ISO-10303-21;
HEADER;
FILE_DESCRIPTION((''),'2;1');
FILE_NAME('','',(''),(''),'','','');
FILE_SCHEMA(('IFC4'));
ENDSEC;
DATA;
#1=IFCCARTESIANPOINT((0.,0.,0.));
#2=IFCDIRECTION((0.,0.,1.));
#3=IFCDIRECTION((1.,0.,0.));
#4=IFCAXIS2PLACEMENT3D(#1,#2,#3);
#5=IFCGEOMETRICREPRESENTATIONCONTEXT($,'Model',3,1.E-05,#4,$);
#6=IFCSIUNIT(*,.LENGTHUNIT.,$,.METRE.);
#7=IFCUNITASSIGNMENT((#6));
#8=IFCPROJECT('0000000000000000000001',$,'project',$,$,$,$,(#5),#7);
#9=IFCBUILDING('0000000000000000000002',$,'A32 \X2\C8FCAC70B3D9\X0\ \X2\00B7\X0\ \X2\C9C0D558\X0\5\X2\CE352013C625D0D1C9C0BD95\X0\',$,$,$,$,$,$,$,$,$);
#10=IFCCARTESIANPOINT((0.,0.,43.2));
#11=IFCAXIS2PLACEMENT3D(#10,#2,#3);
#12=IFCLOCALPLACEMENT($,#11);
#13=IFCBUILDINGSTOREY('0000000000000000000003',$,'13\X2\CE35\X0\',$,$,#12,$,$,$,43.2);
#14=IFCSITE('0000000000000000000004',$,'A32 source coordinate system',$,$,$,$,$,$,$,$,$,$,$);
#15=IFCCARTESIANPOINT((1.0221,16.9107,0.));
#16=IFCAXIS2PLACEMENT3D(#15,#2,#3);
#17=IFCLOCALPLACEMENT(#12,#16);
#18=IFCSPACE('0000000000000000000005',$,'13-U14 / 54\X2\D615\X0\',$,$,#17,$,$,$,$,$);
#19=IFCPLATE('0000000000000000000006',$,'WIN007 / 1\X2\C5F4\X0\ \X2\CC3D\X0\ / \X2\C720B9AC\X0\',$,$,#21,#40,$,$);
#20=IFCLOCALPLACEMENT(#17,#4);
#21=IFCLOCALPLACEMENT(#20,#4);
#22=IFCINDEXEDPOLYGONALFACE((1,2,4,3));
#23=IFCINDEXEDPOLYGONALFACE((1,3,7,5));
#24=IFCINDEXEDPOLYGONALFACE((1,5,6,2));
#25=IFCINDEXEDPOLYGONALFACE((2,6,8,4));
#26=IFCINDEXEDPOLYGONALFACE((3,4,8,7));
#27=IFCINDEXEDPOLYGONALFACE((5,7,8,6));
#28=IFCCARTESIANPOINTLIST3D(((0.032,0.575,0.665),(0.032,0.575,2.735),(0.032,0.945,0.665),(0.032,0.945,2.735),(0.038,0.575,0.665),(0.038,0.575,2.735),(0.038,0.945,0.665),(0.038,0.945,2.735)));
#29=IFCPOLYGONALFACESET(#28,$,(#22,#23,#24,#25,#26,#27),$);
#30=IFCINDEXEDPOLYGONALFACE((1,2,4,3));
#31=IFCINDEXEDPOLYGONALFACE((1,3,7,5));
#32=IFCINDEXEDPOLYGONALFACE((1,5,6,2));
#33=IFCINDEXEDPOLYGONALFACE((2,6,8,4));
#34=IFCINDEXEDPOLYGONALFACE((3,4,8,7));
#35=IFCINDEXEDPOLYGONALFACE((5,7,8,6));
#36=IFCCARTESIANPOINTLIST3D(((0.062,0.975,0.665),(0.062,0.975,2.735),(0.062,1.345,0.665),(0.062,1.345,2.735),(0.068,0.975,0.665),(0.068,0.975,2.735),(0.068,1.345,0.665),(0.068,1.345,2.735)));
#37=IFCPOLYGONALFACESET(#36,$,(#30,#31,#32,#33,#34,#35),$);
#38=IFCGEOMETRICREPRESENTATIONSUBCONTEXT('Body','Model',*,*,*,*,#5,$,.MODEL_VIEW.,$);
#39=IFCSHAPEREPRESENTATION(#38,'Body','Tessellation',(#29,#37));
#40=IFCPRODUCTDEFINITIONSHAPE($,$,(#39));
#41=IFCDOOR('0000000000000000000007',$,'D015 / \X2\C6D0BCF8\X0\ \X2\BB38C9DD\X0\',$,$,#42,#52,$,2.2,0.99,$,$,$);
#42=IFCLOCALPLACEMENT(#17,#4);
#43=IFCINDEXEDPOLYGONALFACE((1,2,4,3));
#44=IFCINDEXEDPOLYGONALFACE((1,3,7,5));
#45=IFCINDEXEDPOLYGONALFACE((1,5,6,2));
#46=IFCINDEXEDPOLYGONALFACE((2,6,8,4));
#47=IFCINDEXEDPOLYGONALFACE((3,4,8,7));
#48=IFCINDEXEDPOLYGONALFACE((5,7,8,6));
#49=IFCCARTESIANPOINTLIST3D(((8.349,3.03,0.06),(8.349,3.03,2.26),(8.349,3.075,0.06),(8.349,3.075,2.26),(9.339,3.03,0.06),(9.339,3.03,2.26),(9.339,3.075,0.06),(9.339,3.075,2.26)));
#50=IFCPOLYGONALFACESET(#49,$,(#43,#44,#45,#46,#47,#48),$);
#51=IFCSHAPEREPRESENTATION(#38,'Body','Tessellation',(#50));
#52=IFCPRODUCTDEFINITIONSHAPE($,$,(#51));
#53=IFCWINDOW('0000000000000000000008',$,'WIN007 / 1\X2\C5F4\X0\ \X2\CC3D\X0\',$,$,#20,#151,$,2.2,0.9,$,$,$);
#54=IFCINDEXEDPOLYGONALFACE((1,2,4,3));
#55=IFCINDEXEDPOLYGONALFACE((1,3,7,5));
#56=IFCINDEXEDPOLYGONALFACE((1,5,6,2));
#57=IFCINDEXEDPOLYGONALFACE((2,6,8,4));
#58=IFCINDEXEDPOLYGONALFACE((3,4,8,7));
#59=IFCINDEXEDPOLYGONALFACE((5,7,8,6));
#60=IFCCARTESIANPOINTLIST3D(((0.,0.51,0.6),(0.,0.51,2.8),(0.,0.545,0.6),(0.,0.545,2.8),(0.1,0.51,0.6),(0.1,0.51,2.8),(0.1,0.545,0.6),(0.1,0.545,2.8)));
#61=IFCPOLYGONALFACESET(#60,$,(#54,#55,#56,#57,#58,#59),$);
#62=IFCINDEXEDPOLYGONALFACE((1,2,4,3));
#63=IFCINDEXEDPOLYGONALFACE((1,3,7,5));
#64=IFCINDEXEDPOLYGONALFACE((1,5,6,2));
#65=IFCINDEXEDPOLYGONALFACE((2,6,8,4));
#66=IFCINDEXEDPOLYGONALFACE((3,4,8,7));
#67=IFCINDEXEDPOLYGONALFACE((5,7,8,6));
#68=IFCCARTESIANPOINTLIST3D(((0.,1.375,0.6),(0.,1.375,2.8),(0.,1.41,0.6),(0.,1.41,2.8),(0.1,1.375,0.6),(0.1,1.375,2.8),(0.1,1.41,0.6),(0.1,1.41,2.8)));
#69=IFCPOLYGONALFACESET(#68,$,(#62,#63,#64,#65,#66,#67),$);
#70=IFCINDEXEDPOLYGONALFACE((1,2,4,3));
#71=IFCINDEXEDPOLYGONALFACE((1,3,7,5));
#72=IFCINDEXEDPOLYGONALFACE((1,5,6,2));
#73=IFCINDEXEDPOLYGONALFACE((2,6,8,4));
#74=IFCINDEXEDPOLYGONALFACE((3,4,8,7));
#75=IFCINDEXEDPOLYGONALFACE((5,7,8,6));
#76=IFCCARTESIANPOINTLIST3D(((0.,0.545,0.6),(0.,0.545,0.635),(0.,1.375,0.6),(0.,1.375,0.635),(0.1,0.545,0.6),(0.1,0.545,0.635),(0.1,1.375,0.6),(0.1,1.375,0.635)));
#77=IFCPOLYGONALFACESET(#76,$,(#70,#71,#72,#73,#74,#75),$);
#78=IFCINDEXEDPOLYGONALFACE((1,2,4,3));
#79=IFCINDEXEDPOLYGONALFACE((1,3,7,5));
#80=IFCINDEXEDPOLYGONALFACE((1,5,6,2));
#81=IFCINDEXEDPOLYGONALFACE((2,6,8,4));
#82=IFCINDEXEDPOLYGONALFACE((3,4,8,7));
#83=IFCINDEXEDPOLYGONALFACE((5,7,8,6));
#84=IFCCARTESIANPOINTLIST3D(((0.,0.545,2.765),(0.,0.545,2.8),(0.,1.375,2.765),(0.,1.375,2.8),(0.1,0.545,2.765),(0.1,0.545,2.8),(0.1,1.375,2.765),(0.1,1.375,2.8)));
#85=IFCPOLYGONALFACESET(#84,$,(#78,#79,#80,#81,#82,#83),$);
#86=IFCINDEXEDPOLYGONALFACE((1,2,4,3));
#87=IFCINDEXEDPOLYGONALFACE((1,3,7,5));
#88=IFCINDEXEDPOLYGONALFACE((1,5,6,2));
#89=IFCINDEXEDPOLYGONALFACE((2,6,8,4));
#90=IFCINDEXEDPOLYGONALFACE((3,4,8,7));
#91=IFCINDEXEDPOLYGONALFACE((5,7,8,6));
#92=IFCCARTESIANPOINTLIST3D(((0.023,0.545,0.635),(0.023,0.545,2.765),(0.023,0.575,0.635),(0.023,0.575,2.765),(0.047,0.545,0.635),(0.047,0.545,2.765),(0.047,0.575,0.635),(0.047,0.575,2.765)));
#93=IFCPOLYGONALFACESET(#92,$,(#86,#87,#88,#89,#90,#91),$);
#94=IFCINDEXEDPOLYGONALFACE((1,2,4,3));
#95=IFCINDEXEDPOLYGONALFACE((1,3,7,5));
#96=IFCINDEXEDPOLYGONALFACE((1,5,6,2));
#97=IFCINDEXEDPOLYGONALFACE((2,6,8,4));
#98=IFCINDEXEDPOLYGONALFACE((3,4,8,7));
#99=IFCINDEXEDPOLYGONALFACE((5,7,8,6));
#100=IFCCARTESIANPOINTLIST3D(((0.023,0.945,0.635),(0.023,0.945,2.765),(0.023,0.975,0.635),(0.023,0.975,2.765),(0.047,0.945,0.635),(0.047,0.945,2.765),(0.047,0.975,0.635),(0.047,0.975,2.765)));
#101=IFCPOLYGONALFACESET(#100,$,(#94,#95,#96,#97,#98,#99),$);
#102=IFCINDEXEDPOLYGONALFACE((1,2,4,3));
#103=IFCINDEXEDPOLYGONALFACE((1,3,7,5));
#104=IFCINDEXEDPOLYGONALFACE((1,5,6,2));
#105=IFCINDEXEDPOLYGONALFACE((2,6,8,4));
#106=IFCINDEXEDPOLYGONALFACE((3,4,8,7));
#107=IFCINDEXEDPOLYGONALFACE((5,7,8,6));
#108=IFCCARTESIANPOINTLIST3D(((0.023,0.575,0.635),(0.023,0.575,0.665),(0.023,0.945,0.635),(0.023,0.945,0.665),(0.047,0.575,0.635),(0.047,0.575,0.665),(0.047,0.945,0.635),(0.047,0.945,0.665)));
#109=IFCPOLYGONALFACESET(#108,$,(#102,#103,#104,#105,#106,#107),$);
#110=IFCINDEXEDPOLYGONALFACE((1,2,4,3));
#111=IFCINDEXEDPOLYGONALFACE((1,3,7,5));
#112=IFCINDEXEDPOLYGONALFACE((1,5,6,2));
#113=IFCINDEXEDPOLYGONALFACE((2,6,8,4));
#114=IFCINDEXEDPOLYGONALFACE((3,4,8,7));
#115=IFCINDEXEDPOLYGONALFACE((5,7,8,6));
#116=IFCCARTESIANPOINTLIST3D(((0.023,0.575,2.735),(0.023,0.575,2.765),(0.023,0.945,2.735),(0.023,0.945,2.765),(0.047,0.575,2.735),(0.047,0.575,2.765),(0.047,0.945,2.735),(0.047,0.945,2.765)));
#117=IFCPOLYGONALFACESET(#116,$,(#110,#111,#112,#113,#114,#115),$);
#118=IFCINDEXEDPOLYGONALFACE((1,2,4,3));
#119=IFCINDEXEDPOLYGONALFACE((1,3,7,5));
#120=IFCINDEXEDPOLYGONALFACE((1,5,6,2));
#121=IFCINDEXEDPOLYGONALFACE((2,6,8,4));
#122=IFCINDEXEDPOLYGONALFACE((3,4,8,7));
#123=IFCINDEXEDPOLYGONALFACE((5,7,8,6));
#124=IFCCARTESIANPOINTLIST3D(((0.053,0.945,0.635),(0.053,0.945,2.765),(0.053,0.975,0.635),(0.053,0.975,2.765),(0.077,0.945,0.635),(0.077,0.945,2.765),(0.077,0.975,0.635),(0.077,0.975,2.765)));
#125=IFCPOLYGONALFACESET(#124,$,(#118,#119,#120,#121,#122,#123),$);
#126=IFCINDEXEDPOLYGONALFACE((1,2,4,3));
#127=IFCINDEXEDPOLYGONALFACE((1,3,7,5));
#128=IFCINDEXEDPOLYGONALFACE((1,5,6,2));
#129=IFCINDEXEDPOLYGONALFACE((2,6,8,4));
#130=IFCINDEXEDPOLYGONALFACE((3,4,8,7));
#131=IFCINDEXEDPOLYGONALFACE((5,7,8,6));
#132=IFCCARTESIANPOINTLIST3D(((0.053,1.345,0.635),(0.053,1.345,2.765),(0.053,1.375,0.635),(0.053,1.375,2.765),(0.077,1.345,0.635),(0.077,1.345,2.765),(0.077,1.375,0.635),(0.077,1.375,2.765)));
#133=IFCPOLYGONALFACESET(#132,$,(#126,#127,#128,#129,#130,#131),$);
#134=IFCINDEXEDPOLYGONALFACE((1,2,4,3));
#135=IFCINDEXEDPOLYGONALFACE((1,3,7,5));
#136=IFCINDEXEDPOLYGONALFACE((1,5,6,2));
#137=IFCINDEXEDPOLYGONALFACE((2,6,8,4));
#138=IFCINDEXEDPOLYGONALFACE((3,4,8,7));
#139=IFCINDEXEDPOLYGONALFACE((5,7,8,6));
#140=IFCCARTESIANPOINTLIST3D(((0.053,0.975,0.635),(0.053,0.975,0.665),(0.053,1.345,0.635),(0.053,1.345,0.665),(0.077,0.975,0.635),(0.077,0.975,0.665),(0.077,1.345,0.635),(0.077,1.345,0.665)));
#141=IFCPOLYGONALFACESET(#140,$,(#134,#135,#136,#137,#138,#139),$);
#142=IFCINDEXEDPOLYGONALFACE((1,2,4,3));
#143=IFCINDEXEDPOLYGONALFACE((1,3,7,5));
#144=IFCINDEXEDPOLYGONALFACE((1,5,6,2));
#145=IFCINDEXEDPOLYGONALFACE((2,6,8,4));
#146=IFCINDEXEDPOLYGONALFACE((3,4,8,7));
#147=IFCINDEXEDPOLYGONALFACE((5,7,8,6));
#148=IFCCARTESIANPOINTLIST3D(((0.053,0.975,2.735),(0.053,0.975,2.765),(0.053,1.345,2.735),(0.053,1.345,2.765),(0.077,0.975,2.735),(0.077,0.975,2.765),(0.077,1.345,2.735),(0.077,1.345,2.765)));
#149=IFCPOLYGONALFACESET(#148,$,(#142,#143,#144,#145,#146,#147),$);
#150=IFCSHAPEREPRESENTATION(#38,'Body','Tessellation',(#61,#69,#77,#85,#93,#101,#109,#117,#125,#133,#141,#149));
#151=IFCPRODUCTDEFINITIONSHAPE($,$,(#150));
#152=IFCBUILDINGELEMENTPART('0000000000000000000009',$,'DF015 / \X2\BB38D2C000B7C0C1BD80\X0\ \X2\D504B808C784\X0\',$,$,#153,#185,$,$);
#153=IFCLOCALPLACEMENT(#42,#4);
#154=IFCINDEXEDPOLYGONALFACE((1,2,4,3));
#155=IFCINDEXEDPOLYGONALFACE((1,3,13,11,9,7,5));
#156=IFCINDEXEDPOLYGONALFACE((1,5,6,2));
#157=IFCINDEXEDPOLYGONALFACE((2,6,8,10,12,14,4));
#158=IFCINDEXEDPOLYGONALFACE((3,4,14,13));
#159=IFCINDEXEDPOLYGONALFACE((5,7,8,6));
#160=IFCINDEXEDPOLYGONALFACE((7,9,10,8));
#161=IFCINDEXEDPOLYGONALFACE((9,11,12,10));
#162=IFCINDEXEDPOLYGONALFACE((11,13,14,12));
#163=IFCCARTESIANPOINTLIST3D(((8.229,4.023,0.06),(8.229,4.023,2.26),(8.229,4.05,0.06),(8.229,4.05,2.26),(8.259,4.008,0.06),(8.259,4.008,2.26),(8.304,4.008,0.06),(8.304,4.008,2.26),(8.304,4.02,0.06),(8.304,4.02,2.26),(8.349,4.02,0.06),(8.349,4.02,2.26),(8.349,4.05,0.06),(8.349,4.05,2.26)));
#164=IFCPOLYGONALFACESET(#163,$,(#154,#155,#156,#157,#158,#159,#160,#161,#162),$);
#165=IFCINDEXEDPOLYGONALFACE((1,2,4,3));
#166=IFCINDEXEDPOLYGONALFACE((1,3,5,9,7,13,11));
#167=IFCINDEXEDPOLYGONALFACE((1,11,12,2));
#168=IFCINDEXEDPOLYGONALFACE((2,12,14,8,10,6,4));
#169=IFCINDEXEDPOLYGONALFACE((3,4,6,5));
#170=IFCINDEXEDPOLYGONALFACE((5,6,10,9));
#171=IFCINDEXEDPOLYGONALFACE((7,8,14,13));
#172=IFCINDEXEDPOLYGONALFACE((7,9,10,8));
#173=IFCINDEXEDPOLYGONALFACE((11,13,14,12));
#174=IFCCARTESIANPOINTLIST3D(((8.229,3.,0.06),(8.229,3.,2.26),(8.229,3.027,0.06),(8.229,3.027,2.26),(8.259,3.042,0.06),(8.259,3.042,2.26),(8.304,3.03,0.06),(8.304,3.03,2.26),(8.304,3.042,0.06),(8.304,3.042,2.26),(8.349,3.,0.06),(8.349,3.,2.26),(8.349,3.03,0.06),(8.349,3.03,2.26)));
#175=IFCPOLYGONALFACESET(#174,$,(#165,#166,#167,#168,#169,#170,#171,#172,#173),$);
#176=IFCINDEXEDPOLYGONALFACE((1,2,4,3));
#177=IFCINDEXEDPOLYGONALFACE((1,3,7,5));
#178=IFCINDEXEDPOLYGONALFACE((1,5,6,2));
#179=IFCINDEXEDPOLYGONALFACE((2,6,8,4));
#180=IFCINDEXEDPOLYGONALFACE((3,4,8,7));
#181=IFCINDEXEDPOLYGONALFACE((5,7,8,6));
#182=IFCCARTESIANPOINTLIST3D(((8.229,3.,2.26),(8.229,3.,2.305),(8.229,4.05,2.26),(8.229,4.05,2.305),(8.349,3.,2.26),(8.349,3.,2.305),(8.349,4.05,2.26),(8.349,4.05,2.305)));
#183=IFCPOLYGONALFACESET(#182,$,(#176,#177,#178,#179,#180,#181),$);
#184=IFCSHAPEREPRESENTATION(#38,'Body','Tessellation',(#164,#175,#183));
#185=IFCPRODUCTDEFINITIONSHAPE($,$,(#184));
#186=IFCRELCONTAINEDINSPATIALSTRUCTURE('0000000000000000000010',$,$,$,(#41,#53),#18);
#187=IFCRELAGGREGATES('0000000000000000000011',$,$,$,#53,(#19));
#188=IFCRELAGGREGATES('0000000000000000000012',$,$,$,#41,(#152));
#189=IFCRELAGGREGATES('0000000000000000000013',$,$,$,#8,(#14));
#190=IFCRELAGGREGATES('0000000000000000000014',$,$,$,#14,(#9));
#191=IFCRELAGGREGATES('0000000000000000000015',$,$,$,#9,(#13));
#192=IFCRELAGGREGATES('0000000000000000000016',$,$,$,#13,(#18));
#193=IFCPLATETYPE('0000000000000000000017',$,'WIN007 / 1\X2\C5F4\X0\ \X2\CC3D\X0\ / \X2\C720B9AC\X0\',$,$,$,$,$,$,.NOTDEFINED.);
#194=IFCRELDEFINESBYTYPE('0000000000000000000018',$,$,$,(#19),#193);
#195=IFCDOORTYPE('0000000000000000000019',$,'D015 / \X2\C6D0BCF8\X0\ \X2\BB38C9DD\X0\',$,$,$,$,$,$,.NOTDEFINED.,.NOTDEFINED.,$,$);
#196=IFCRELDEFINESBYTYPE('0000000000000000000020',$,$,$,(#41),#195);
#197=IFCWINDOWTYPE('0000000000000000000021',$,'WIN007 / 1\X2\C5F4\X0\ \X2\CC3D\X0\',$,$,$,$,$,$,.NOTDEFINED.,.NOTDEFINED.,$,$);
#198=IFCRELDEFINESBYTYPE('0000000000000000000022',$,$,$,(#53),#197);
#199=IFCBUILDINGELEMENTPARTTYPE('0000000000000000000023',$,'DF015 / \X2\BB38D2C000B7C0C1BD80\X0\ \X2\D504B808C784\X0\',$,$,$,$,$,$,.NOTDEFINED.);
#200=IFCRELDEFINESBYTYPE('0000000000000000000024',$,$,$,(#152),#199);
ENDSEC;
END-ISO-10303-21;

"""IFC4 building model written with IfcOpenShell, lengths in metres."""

from ifc_helpers import new_model, si_unit, frame, origin, origin_with_axes, place, context, subcontext, project, spatial, polyline, outline, extrude, source, transform, mapped, type_object, type_shapes, element, aggregate, save


model = new_model("IFC4")

# Units and contexts
model_context = context("Model", 3, precision=1e-05, world=origin_with_axes())
body_context = subcontext(model_context, "Body", "Model", "MODEL_VIEW")
ifc_project = project(units=[si_unit("LENGTHUNIT", "METRE")], contexts=[model_context])

# Plate
plate_type_1 = type_object("IfcPlateType", Name="WIN007 / 1열 창 / 유리", PredefinedType="NOTDEFINED")
shared_shape_1 = source(origin(), body_context, "Body", "SweptSolid", [
    extrude(outline(polyline([(0.032, 0.575), (0.032, 0.945), (0.038, 0.945), (0.038, 0.575), (0.032, 0.575)])), frame((0.0, 0.0, 0.665)), (0.0, 0.0, 1.0), 2.07),
    extrude(outline(polyline([(0.062, 0.975), (0.062, 1.345), (0.068, 1.345), (0.068, 0.975), (0.062, 0.975)])), frame((0.0, 0.0, 0.665)), (0.0, 0.0, 1.0), 2.07),
])
type_shapes(plate_type_1, [shared_shape_1])
storey_placement = place(None, frame((0.0, 0.0, 43.2), z_axis=(0.0, 0.0, 1.0), x_axis=(1.0, 0.0, 0.0)))
space_1_placement = place(storey_placement, frame((1.0221, 16.9107, 0.0), z_axis=(0.0, 0.0, 1.0), x_axis=(1.0, 0.0, 0.0)))
window_1_placement = place(space_1_placement, origin_with_axes())
plate_1_placement = place(window_1_placement, origin_with_axes())
plate_1 = element("IfcPlate", 1, at=plate_1_placement, type_object=plate_type_1, Name="WIN007 / 1열 창 / 유리", context=body_context, shape_type="MappedRepresentation", body=[
    mapped(shared_shape_1, transform((0.0, 0.0, 0.0), scale=1.0)),
])

# Site, building, storey, space
site = spatial("IfcSite", under=ifc_project, Name="A32 source coordinate system")
building = spatial("IfcBuilding", under=site, Name="A32 주거동 · 지하5층–옥탑지붕")
storey = spatial("IfcBuildingStorey", under=building, at=storey_placement, Name="13층", Elevation=43.2)
space_1 = spatial("IfcSpace", under=storey, at=space_1_placement, Name="13-U14 / 54형")

# Door
door_type_1 = type_object("IfcDoorType", Name="D015 / 원본 문짝", OperationType="NOTDEFINED", PredefinedType="NOTDEFINED")
shared_shape_2 = source(origin(), body_context, "Body", "SweptSolid", [
    extrude(outline(polyline([(9.339, 3.075), (9.339, 3.03), (8.349, 3.03), (8.349, 3.075), (9.339, 3.075)])), frame((0.0, 0.0, 0.06)), (0.0, 0.0, 1.0), 2.2),
])
type_shapes(door_type_1, [shared_shape_2])
door_1_placement = place(space_1_placement, origin_with_axes())
door_1 = element("IfcDoor", 2, at=door_1_placement, inside=space_1, type_object=door_type_1, Name="D015 / 원본 문짝", OverallHeight=2.2, OverallWidth=0.99, context=body_context, shape_type="MappedRepresentation", body=[
    mapped(shared_shape_2, transform((0.0, 0.0, 0.0), scale=1.0)),
])

# Window
window_type_1 = type_object("IfcWindowType", Name="WIN007 / 1열 창", PartitioningType="NOTDEFINED", PredefinedType="NOTDEFINED")
shared_shape_3 = source(origin(), body_context, "Body", "SweptSolid", [
    extrude(outline(polyline([(0.0, 0.51), (0.0, 0.545), (0.1, 0.545), (0.1, 0.51), (0.0, 0.51)])), frame((0.0, 0.0, 0.6)), (0.0, 0.0, 1.0), 2.2),
    extrude(outline(polyline([(0.0, 1.375), (0.0, 1.41), (0.1, 1.41), (0.1, 1.375), (0.0, 1.375)])), frame((0.0, 0.0, 0.6)), (0.0, 0.0, 1.0), 2.2),
    extrude(outline(polyline([(0.0, 0.545), (0.0, 1.375), (0.1, 1.375), (0.1, 0.545), (0.0, 0.545)])), frame((0.0, 0.0, 0.6)), (0.0, 0.0, 1.0), 0.035),
    extrude(outline(polyline([(0.0, 0.545), (0.0, 1.375), (0.1, 1.375), (0.1, 0.545), (0.0, 0.545)])), frame((0.0, 0.0, 2.765)), (0.0, 0.0, 1.0), 0.035),
    extrude(outline(polyline([(0.023, 0.545), (0.023, 0.575), (0.047, 0.575), (0.047, 0.545), (0.023, 0.545)])), frame((0.0, 0.0, 0.635)), (0.0, 0.0, 1.0), 2.13),
    extrude(outline(polyline([(0.023, 0.945), (0.023, 0.975), (0.047, 0.975), (0.047, 0.945), (0.023, 0.945)])), frame((0.0, 0.0, 0.635)), (0.0, 0.0, 1.0), 2.13),
    extrude(outline(polyline([(0.023, 0.575), (0.023, 0.945), (0.047, 0.945), (0.047, 0.575), (0.023, 0.575)])), frame((0.0, 0.0, 0.635)), (0.0, 0.0, 1.0), 0.03),
    extrude(outline(polyline([(0.023, 0.575), (0.023, 0.945), (0.047, 0.945), (0.047, 0.575), (0.023, 0.575)])), frame((0.0, 0.0, 2.735)), (0.0, 0.0, 1.0), 0.03),
    extrude(outline(polyline([(0.053, 0.945), (0.053, 0.975), (0.077, 0.975), (0.077, 0.945), (0.053, 0.945)])), frame((0.0, 0.0, 0.635)), (0.0, 0.0, 1.0), 2.13),
    extrude(outline(polyline([(0.053, 1.345), (0.053, 1.375), (0.077, 1.375), (0.077, 1.345), (0.053, 1.345)])), frame((0.0, 0.0, 0.635)), (0.0, 0.0, 1.0), 2.13),
    extrude(outline(polyline([(0.053, 0.975), (0.053, 1.345), (0.077, 1.345), (0.077, 0.975), (0.053, 0.975)])), frame((0.0, 0.0, 0.635)), (0.0, 0.0, 1.0), 0.03),
    extrude(outline(polyline([(0.053, 0.975), (0.053, 1.345), (0.077, 1.345), (0.077, 0.975), (0.053, 0.975)])), frame((0.0, 0.0, 2.735)), (0.0, 0.0, 1.0), 0.03),
])
type_shapes(window_type_1, [shared_shape_3])
window_1 = element("IfcWindow", 3, at=window_1_placement, inside=space_1, type_object=window_type_1, Name="WIN007 / 1열 창", OverallHeight=2.2, OverallWidth=0.9, context=body_context, shape_type="MappedRepresentation", body=[
    mapped(shared_shape_3, transform((0.0, 0.0, 0.0), scale=1.0)),
])
aggregate(window_1, [plate_1])

# Building element part
building_element_part_type_1 = type_object("IfcBuildingElementPartType", Name="DF015 / 문틀·상부 프레임", PredefinedType="NOTDEFINED")
shared_shape_4 = source(origin(), body_context, "Body", "SweptSolid", [
    extrude(outline(polyline([(8.349, 4.02), (8.304, 4.02), (8.304, 4.008), (8.259, 4.008), (8.229, 4.023), (8.229, 4.05), (8.349, 4.05), (8.349, 4.02)])), frame((0.0, 0.0, 0.06)), (0.0, 0.0, 1.0), 2.2),
    extrude(outline(polyline([(8.229, 3.0), (8.229, 3.027), (8.259, 3.042), (8.304, 3.042), (8.304, 3.03), (8.349, 3.03), (8.349, 3.0), (8.229, 3.0)])), frame((0.0, 0.0, 0.06)), (0.0, 0.0, 1.0), 2.2),
    extrude(outline(polyline([(8.229, 3.0), (8.229, 4.05), (8.349, 4.05), (8.349, 3.0), (8.229, 3.0)])), frame((0.0, 0.0, 2.26)), (0.0, 0.0, 1.0), 0.045),
])
type_shapes(building_element_part_type_1, [shared_shape_4])
building_element_part_1_placement = place(door_1_placement, origin_with_axes())
building_element_part_1 = element("IfcBuildingElementPart", 4, at=building_element_part_1_placement, type_object=building_element_part_type_1, Name="DF015 / 문틀·상부 프레임", context=body_context, shape_type="MappedRepresentation", body=[
    mapped(shared_shape_4, transform((0.0, 0.0, 0.0), scale=1.0)),
])
aggregate(door_1, [building_element_part_1])

save(model, "model.ifc")
